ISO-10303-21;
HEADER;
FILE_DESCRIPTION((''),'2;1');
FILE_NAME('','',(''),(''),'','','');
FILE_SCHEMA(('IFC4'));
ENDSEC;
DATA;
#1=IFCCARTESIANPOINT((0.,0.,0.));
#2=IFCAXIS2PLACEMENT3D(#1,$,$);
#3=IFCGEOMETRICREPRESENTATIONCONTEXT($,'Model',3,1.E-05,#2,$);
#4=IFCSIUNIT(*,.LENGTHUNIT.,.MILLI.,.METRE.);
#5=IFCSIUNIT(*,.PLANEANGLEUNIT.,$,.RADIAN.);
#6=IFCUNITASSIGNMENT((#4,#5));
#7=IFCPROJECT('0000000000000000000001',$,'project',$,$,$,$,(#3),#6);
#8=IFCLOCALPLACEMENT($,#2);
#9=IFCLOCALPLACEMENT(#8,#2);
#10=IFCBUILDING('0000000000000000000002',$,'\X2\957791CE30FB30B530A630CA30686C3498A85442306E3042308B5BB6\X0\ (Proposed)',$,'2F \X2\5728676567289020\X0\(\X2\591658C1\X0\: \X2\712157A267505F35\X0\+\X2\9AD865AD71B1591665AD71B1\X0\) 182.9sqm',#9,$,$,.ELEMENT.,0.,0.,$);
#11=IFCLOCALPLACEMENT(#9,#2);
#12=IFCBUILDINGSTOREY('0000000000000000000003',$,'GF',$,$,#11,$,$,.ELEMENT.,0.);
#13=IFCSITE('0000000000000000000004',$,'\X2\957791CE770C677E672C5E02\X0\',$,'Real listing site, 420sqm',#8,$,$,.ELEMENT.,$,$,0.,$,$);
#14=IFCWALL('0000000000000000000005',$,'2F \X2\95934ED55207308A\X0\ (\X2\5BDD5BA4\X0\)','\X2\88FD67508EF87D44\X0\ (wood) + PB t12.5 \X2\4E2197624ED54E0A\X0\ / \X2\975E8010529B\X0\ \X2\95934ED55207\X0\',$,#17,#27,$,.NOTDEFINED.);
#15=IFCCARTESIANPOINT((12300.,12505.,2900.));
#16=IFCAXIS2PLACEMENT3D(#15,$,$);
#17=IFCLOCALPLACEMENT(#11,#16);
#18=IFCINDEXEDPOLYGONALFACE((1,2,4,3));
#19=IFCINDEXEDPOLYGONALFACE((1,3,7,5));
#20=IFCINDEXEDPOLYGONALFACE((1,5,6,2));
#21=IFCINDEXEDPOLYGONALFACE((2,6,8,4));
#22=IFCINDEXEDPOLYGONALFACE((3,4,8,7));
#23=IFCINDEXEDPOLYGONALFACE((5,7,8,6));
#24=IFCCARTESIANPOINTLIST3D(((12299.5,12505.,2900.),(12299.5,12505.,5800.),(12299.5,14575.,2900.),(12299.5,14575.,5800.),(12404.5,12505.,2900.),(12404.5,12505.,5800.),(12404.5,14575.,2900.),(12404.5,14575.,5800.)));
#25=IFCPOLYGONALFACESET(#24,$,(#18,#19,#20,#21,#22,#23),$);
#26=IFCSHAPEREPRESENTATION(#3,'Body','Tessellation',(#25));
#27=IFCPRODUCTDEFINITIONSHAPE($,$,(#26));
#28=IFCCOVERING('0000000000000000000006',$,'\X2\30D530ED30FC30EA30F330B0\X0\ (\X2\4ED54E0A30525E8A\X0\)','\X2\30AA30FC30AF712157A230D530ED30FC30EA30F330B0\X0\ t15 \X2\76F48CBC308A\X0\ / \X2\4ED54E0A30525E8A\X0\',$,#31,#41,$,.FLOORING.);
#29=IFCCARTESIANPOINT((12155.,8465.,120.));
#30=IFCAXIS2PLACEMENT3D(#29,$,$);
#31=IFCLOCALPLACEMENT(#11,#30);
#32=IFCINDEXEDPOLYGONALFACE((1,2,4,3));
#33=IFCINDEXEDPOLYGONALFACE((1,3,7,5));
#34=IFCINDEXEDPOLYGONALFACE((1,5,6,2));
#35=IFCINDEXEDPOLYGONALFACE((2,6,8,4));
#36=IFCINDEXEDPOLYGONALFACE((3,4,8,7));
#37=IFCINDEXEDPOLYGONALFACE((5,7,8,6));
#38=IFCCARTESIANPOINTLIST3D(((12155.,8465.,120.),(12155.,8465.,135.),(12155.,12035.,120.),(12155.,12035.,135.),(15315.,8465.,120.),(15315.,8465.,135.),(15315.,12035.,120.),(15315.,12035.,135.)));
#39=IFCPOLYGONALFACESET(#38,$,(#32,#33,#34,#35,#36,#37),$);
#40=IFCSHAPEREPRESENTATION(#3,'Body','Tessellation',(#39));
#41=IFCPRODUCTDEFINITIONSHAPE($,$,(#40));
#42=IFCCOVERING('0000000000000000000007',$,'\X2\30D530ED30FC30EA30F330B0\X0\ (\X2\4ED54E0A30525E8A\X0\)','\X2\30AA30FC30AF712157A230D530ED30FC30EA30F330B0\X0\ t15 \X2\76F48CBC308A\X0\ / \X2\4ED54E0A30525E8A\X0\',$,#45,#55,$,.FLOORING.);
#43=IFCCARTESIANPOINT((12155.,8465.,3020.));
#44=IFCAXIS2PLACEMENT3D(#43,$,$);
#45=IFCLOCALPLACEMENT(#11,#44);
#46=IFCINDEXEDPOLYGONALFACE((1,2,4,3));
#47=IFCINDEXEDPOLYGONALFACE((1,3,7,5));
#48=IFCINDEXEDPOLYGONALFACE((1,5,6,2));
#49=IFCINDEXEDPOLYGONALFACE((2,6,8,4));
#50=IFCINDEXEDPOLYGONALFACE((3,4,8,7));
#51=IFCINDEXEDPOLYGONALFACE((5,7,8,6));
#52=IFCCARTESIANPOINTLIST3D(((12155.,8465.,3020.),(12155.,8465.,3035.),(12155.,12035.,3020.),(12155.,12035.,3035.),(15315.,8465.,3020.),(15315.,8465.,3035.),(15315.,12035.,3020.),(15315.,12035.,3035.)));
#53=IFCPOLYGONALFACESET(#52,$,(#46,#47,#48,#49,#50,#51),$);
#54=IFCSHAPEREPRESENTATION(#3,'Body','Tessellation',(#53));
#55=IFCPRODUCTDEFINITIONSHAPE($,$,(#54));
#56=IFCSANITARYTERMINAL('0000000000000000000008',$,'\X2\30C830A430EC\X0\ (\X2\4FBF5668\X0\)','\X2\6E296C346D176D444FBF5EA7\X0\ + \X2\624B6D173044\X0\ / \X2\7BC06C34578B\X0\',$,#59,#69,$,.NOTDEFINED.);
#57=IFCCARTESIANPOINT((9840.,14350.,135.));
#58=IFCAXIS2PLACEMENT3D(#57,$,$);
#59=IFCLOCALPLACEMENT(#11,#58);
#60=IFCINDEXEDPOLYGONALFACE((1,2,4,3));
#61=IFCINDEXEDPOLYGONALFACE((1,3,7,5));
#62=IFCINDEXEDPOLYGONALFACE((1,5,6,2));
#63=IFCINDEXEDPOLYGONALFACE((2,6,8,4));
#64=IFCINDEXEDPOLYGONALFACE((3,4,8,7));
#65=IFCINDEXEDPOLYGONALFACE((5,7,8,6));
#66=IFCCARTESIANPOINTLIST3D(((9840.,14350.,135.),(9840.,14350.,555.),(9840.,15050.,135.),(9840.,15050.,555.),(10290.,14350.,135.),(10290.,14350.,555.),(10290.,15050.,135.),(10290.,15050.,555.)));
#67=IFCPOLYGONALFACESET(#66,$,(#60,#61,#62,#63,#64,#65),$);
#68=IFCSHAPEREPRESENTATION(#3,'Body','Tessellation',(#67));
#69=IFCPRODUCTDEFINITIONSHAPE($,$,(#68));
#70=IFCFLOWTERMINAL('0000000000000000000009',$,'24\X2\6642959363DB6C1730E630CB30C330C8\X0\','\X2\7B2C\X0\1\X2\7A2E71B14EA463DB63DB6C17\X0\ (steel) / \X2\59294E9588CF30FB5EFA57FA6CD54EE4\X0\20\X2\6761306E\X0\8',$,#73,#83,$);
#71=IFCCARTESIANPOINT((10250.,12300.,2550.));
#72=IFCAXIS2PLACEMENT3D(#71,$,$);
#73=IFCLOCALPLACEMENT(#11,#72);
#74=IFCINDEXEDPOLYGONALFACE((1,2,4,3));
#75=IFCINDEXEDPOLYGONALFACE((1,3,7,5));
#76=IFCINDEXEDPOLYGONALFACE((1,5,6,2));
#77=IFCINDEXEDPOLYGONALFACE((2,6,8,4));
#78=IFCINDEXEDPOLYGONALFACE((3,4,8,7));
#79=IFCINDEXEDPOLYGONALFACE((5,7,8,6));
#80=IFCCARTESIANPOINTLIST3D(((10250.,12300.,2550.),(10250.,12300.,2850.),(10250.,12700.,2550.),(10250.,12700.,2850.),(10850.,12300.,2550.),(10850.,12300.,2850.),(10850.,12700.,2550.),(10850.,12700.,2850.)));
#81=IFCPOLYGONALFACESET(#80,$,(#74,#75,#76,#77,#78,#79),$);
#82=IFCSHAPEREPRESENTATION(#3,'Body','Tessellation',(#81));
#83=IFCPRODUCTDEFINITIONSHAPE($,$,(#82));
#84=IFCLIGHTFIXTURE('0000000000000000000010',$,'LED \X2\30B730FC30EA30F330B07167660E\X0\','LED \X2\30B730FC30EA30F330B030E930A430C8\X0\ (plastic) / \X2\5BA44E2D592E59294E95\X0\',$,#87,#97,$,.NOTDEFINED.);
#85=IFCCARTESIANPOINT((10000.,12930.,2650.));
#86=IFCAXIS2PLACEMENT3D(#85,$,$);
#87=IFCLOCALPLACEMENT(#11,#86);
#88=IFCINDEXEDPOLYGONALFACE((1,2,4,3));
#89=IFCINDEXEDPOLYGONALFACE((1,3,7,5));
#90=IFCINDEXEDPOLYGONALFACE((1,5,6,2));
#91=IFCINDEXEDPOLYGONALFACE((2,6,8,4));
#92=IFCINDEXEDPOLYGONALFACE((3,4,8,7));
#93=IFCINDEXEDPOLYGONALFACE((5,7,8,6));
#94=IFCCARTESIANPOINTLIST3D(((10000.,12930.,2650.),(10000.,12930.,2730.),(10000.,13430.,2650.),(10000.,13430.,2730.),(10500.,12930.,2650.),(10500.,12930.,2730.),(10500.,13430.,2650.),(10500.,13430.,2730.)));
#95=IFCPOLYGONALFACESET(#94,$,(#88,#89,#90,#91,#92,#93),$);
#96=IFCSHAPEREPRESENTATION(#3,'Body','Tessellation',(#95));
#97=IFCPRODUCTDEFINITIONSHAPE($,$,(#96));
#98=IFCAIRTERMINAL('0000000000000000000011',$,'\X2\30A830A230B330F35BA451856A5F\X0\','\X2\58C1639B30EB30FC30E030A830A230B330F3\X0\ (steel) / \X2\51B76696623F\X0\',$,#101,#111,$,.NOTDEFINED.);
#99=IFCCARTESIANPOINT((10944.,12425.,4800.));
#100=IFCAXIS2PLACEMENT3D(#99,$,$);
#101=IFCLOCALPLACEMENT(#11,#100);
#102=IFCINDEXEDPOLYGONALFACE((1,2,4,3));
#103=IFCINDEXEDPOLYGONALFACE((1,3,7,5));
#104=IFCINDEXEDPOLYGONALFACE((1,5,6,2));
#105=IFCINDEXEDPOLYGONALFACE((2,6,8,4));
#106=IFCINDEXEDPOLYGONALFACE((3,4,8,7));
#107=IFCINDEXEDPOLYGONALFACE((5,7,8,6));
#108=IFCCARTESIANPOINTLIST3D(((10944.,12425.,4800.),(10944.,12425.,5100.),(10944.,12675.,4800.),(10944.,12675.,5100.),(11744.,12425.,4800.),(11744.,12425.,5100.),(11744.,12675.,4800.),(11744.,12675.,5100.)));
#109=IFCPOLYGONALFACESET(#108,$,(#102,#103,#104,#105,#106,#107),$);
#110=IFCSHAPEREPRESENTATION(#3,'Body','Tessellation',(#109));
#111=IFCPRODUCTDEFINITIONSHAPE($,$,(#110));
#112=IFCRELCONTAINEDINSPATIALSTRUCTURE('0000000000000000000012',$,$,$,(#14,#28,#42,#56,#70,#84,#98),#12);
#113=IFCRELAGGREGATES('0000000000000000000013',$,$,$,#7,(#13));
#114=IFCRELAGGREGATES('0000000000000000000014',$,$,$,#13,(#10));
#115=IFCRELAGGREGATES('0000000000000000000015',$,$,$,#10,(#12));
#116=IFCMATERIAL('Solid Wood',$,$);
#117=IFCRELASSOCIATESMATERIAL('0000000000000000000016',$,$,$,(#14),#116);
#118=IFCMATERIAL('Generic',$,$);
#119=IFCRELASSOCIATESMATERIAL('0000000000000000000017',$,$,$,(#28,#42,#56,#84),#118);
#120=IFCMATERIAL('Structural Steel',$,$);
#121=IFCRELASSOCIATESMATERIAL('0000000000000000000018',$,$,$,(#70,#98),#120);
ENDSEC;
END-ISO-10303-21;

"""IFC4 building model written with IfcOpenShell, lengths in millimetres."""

from ifc_helpers import new_model, si_unit, frame, frame_2d, origin, place, context, project, spatial, rectangle, extrude, material, element, save


model = new_model("IFC4")

# Units and contexts
model_context = context("Model", 3, precision=1e-05, world=origin())
ifc_project = project(units=[si_unit("LENGTHUNIT", "METRE", prefix="MILLI"), si_unit("PLANEANGLEUNIT", "RADIAN")], contexts=[model_context])

# Site, building, storey
site_placement = place(None, origin())
site = spatial("IfcSite", under=ifc_project, at=site_placement, Name="長野県松本市", ObjectType="Real listing site, 420sqm", CompositionType="ELEMENT", RefElevation=0.0)
building_placement = place(site_placement, origin())
building = spatial("IfcBuilding", under=site, at=building_placement, Name="長野・サウナと水風呂のある家 (Proposed)", ObjectType="2F 在来木造(外壁: 無垢材張+高断熱外断熱) 182.9sqm", CompositionType="ELEMENT", ElevationOfRefHeight=0.0, ElevationOfTerrain=0.0)
storey_placement = place(building_placement, origin())
storey = spatial("IfcBuildingStorey", under=building, at=storey_placement, Name="GF", CompositionType="ELEMENT", Elevation=0.0)

# Shared definitions
ifc_material_1 = material(Name="Solid Wood")

# Wall
wall_1_placement = place(storey_placement, frame((12300.0, 12505.0, 2900.0)))
element("IfcWall", 1, at=wall_1_placement, inside=storey, material=ifc_material_1, Name="2F 間仕切り (寝室)", Description="製材軸組 (wood) + PB t12.5 両面仕上 / 非耐力 間仕切", PredefinedType="NOTDEFINED", context=model_context, shape_type="SweptSolid", body=[
    extrude(rectangle(XDim=105.0, YDim=2070.0, at=frame_2d((52.0, 1035.0))), frame((12300.0, 12505.0, 2900.0)), (0.0, 0.0, 1.0), 2900.0),
])

# Coverings
ifc_material_2 = material(Name="Generic")
covering_1_placement = place(storey_placement, frame((12155.0, 8465.0, 120.0)))
element("IfcCovering", 2, at=covering_1_placement, inside=storey, material=ifc_material_2, Name="フローリング (仕上げ床)", Description="オーク無垢フローリング t15 直貼り / 仕上げ床", PredefinedType="FLOORING", context=model_context, shape_type="SweptSolid", body=[
    extrude(rectangle(XDim=3160.0, YDim=3570.0, at=frame_2d((1580.0, 1785.0))), frame((12155.0, 8465.0, 120.0)), (0.0, 0.0, 1.0), 15.0),
])
covering_2_placement = place(storey_placement, frame((12155.0, 8465.0, 3020.0)))
element("IfcCovering", 3, at=covering_2_placement, inside=storey, material=ifc_material_2, Name="フローリング (仕上げ床)", Description="オーク無垢フローリング t15 直貼り / 仕上げ床", PredefinedType="FLOORING", context=model_context, shape_type="SweptSolid", body=[
    extrude(rectangle(XDim=3160.0, YDim=3570.0, at=frame_2d((1580.0, 1785.0))), frame((12155.0, 8465.0, 3020.0)), (0.0, 0.0, 1.0), 15.0),
])

# Sanitary terminal
sanitary_terminal_placement = place(storey_placement, frame((9840.0, 14350.0, 135.0)))
element("IfcSanitaryTerminal", 4, at=sanitary_terminal_placement, inside=storey, material=ifc_material_2, Name="トイレ (便器)", Description="温水洗浄便座 + 手洗い / 節水型", PredefinedType="NOTDEFINED", context=model_context, shape_type="SweptSolid", body=[
    extrude(rectangle(XDim=450.0, YDim=700.0, at=frame_2d((225.0, 350.0))), frame((9840.0, 14350.0, 135.0)), (0.0, 0.0, 1.0), 420.0),
])

# Flow terminal
ifc_material_3 = material(Name="Structural Steel")
flow_terminal_placement = place(storey_placement, frame((10250.0, 12300.0, 2550.0)))
element("IfcFlowTerminal", 5, at=flow_terminal_placement, inside=storey, material=ifc_material_3, Name="24時間換気ユニット", Description="第1種熱交換換気 (steel) / 天井裏・建基法令20条の8", context=model_context, shape_type="SweptSolid", body=[
    extrude(rectangle(XDim=600.0, YDim=400.0, at=frame_2d((300.0, 200.0))), frame((10250.0, 12300.0, 2550.0)), (0.0, 0.0, 1.0), 300.0),
])

# Light fixture
light_fixture_placement = place(storey_placement, frame((10000.0, 12930.0, 2650.0)))
element("IfcLightFixture", 6, at=light_fixture_placement, inside=storey, material=ifc_material_2, Name="LED シーリング照明", Description="LED シーリングライト (plastic) / 室中央天井", PredefinedType="NOTDEFINED", context=model_context, shape_type="SweptSolid", body=[
    extrude(rectangle(XDim=500.0, YDim=500.0, at=frame_2d((250.0, 250.0))), frame((10000.0, 12930.0, 2650.0)), (0.0, 0.0, 1.0), 80.0),
])

# Air terminal
air_terminal_placement = place(storey_placement, frame((10944.0, 12425.0, 4800.0)))
element("IfcAirTerminal", 7, at=air_terminal_placement, inside=storey, material=ifc_material_3, Name="エアコン室内機", Description="壁掛ルームエアコン (steel) / 冷暖房", PredefinedType="NOTDEFINED", context=model_context, shape_type="SweptSolid", body=[
    extrude(rectangle(XDim=800.0, YDim=250.0, at=frame_2d((400.0, 125.0))), frame((10944.0, 12425.0, 4800.0)), (0.0, 0.0, 1.0), 300.0),
])

save(model, "model.ifc")
